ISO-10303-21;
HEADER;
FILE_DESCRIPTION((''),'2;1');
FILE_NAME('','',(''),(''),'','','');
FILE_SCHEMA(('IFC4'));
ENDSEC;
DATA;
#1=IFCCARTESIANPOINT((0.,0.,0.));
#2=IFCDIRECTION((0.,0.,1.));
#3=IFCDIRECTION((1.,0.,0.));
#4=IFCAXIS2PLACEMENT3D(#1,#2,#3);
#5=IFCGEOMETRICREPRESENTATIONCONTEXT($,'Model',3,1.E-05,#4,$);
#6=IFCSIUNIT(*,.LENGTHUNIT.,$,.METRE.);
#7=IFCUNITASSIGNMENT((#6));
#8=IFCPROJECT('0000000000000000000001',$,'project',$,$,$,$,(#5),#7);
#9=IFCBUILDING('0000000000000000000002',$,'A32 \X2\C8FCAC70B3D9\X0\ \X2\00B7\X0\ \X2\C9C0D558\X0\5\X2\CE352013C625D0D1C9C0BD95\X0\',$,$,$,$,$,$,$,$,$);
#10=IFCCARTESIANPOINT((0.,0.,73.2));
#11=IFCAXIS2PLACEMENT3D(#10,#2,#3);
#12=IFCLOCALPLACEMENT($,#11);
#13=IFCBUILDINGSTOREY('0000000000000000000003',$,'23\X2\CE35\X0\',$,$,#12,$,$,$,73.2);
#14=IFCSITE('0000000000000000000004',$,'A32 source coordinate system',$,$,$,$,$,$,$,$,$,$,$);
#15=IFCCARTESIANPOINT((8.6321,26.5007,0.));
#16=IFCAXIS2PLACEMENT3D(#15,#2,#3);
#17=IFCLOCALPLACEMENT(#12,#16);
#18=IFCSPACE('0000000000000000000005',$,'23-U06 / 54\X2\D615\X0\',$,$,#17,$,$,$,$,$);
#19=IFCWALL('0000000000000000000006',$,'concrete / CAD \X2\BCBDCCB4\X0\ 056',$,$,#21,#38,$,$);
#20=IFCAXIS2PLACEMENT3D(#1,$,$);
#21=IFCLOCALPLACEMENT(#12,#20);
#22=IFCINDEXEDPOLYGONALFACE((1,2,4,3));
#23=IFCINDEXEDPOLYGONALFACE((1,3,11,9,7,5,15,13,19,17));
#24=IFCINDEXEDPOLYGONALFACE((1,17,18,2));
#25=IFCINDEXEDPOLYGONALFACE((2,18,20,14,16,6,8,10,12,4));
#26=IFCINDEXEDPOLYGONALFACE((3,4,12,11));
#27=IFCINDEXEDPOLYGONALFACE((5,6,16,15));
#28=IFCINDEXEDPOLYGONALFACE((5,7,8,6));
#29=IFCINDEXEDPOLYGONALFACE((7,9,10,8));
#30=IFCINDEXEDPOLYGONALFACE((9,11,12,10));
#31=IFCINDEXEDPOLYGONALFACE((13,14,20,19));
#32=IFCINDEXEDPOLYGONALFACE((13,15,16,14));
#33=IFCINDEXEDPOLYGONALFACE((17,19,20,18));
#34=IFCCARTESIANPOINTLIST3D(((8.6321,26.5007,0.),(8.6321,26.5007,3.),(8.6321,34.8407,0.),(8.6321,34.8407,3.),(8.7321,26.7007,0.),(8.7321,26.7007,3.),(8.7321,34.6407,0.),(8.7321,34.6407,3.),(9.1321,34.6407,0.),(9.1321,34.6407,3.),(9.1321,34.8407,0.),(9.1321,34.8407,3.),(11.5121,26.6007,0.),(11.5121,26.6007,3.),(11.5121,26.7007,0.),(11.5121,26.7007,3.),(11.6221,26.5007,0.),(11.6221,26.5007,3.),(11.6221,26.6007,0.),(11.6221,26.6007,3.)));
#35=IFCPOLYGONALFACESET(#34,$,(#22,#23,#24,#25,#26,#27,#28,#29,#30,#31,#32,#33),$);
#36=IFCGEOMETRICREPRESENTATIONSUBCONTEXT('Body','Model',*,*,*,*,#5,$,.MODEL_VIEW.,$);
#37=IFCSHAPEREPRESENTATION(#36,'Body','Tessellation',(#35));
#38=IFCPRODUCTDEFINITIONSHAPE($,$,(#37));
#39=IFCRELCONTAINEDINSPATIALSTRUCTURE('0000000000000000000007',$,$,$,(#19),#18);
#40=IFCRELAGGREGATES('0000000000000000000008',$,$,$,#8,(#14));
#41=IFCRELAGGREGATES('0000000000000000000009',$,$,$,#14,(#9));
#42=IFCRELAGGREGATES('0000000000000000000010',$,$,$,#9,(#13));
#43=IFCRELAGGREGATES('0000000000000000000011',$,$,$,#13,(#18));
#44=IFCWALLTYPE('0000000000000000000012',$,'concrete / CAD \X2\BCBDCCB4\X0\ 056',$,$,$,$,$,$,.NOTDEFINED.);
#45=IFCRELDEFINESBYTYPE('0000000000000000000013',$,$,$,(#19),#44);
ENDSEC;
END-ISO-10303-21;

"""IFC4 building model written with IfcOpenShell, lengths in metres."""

from ifc_helpers import new_model, si_unit, frame, origin, origin_with_axes, place, context, subcontext, project, spatial, polyline, outline, extrude, source, transform, mapped, type_object, type_shapes, element, save


model = new_model("IFC4")

# Units and contexts
model_context = context("Model", 3, precision=1e-05, world=origin_with_axes())
body_context = subcontext(model_context, "Body", "Model", "MODEL_VIEW")
ifc_project = project(units=[si_unit("LENGTHUNIT", "METRE")], contexts=[model_context])

# Site, building, storey, space
site = spatial("IfcSite", under=ifc_project, Name="A32 source coordinate system")
building = spatial("IfcBuilding", under=site, Name="A32 주거동 · 지하5층–옥탑지붕")
storey_placement = place(None, frame((0.0, 0.0, 73.2), z_axis=(0.0, 0.0, 1.0), x_axis=(1.0, 0.0, 0.0)))
storey = spatial("IfcBuildingStorey", under=building, at=storey_placement, Name="23층", Elevation=73.2)
space_placement = place(storey_placement, frame((8.6321, 26.5007, 0.0), z_axis=(0.0, 0.0, 1.0), x_axis=(1.0, 0.0, 0.0)))
space = spatial("IfcSpace", under=storey, at=space_placement, Name="23-U06 / 54형")

# Wall
wall_type_1 = type_object("IfcWallType", Name="concrete / CAD 벽체 056", PredefinedType="NOTDEFINED")
shared_shape_1 = source(origin(), body_context, "Body", "SweptSolid", [
    extrude(outline(polyline([(0.1, 8.14), (0.1, 0.2), (2.88, 0.2), (2.88, 0.1), (2.99, 0.1), (2.99, 0.0), (0.0, 0.0), (0.0, 8.34), (-0.35, 8.34), (-0.35, 8.34), (0.5, 8.34), (0.5, 8.14), (0.1, 8.14)])), origin(), (0.0, 0.0, 1.0), 3.0),
])
type_shapes(wall_type_1, [shared_shape_1])
wall_1_placement = place(space_placement, origin_with_axes())
element("IfcWall", 1, at=wall_1_placement, inside=space, type_object=wall_type_1, Name="concrete / CAD 벽체 056", context=body_context, shape_type="MappedRepresentation", body=[
    mapped(shared_shape_1, transform((0.0, 0.0, 0.0), scale=1.0)),
])

save(model, "model.ifc")
